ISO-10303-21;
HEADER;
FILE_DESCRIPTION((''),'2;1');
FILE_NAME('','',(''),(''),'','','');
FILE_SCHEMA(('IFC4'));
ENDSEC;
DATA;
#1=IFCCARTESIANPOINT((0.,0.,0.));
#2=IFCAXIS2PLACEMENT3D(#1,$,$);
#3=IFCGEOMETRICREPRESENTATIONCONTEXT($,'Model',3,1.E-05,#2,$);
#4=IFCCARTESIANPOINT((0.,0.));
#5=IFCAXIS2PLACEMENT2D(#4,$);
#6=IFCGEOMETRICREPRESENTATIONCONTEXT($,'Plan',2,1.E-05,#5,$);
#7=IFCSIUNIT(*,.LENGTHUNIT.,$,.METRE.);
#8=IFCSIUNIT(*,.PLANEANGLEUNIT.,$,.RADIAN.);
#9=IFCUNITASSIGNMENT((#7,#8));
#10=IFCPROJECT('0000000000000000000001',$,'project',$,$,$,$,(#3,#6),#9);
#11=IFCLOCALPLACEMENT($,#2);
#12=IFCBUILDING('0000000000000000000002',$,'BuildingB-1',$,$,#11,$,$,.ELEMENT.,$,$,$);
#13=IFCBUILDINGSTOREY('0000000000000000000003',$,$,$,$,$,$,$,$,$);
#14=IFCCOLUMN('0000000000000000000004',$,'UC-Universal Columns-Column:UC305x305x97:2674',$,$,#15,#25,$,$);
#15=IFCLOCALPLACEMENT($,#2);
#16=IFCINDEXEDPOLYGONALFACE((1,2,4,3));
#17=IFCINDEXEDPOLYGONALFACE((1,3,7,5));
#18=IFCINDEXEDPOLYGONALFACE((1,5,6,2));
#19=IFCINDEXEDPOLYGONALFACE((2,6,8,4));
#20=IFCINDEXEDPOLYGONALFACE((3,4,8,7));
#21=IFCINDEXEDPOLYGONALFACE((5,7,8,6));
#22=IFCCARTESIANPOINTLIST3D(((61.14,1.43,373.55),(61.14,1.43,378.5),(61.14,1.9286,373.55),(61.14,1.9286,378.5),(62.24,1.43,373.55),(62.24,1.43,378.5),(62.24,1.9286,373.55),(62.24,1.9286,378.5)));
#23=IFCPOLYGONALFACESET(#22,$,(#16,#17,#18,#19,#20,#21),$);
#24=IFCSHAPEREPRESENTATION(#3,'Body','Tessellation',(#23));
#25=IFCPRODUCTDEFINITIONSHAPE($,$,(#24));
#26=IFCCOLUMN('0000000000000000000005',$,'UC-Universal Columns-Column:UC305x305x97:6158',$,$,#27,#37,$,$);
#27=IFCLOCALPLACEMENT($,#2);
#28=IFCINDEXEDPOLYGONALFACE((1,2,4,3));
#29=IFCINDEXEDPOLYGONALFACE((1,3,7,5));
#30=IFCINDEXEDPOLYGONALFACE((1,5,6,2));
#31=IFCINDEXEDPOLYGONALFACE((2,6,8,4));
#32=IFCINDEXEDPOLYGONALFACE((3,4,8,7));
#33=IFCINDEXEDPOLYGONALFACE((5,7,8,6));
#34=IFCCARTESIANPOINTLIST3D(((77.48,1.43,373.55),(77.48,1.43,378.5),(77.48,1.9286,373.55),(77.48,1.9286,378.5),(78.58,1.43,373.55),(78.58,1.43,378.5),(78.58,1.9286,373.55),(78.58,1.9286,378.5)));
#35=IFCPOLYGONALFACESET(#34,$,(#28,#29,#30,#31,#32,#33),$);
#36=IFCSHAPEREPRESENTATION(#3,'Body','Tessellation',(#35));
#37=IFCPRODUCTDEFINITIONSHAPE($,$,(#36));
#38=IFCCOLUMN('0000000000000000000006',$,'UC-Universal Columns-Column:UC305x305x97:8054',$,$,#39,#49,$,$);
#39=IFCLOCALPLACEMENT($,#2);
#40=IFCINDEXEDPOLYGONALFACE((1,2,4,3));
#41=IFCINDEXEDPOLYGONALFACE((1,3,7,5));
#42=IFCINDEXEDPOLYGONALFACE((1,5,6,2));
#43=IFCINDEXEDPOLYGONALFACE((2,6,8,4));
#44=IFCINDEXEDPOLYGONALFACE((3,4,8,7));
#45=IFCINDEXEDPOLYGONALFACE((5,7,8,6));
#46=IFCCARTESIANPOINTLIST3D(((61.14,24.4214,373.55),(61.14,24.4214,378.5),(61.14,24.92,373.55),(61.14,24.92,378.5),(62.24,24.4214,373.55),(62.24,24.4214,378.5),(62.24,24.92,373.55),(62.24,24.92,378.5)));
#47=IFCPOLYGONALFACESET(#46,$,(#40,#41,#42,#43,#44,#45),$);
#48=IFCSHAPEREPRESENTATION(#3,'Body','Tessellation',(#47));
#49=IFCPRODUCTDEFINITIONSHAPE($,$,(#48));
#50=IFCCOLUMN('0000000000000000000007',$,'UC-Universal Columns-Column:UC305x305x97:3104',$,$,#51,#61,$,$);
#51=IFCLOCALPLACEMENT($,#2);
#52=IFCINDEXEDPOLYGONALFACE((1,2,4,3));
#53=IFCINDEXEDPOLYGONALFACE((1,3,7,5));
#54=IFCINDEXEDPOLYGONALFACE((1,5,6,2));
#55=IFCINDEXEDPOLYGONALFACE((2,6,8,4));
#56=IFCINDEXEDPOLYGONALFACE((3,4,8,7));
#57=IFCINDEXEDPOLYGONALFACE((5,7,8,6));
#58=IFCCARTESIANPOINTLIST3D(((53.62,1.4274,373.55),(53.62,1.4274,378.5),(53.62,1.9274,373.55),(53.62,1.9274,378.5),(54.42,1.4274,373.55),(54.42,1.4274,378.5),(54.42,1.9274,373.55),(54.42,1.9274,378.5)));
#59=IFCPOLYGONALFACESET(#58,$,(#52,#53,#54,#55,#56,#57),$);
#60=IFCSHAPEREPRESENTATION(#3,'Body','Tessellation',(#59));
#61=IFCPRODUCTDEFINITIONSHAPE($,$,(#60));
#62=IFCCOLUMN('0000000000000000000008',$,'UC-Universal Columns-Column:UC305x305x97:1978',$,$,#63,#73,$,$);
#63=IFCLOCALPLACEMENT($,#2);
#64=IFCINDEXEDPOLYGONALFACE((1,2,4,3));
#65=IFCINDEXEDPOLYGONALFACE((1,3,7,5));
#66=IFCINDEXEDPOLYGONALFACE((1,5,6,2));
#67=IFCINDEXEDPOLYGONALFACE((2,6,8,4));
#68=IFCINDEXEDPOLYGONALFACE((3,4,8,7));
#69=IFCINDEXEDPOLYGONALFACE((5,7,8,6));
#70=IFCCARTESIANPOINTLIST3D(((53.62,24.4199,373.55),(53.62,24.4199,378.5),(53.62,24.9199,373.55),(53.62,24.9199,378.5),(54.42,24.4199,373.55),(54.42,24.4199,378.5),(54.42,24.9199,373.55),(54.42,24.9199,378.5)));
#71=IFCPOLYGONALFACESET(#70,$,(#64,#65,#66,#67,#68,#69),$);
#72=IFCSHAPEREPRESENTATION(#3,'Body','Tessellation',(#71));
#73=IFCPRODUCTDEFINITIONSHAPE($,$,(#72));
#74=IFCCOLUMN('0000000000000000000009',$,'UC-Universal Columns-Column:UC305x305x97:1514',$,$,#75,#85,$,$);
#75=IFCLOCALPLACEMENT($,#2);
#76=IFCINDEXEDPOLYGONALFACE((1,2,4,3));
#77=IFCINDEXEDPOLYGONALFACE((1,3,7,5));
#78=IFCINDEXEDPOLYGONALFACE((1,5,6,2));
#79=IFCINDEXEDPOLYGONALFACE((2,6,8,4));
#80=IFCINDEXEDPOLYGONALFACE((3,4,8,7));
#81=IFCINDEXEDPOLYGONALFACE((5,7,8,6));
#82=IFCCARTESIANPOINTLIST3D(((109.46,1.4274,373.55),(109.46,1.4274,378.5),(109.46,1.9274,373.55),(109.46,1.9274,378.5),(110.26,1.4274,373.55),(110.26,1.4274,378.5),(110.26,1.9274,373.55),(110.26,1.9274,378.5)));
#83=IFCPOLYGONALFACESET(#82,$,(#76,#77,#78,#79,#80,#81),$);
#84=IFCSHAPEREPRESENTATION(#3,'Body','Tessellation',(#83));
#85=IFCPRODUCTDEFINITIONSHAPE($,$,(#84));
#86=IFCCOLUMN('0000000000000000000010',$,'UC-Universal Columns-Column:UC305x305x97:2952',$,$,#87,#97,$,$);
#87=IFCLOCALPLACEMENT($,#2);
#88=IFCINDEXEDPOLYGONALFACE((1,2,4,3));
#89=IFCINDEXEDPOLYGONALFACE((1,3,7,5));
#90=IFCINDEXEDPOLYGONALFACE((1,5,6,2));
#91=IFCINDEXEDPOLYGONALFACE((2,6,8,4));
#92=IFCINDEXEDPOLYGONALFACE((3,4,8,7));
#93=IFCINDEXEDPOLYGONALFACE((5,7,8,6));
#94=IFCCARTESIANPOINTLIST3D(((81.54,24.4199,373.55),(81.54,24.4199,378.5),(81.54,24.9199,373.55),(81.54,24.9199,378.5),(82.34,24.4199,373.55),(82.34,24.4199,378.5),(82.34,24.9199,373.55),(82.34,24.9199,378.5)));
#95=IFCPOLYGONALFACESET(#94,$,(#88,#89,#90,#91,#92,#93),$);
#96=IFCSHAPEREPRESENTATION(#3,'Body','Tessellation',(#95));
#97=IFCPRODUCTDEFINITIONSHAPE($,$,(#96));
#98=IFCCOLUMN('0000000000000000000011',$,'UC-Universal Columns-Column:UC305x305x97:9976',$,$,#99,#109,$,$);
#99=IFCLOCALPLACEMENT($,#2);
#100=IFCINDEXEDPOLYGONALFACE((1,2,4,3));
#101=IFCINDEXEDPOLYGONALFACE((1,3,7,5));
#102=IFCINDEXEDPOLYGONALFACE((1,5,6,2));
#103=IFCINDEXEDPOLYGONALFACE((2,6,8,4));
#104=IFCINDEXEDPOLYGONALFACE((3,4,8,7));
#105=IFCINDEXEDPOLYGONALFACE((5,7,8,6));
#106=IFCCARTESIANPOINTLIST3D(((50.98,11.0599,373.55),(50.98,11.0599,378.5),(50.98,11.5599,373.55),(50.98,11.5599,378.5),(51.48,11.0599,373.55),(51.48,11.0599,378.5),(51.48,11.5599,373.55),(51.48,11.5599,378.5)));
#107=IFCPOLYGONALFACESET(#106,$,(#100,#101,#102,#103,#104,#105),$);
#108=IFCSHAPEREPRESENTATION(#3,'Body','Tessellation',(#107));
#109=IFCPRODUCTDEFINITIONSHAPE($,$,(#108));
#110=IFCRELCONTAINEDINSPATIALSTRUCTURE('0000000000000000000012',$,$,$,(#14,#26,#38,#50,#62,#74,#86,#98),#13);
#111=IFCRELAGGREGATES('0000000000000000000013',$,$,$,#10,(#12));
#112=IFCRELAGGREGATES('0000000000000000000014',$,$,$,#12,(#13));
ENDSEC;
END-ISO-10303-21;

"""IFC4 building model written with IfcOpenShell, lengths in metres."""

from ifc_helpers import new_model, si_unit, origin, origin_2d, place, context, project, spatial, polyline, outline, extrude, element, save


model = new_model("IFC4")

# Units and contexts
model_context = context("Model", 3, precision=1e-05, world=origin())
plan_context = context("Plan", 2, precision=1e-05, world=origin_2d())
ifc_project = project(units=[si_unit("LENGTHUNIT", "METRE"), si_unit("PLANEANGLEUNIT", "RADIAN")], contexts=[model_context, plan_context])

# Building, storey
building_placement = place(None, origin())
building = spatial("IfcBuilding", under=ifc_project, at=building_placement, Name="BuildingB-1", CompositionType="ELEMENT")
storey = spatial("IfcBuildingStorey", under=building)

# Columns
element("IfcColumn", 1, inside=storey, Name="UC-Universal Columns-Column:UC305x305x97:2674", context=model_context, shape_type="SweptSolid", body=[
    extrude(outline(polyline([(61.14, 1.43, 378.5), (62.24, 1.43, 378.5), (62.24, 1.9286, 378.5), (61.14, 1.9286, 378.5), (61.14, 1.43, 378.5)])), None, (0.0, 0.0, -1.0), 4.95),
])
element("IfcColumn", 2, inside=storey, Name="UC-Universal Columns-Column:UC305x305x97:6158", context=model_context, shape_type="SweptSolid", body=[
    extrude(outline(polyline([(77.48, 1.43, 378.5), (78.58, 1.43, 378.5), (78.58, 1.9286, 378.5), (77.48, 1.9286, 378.5), (77.48, 1.43, 378.5)])), None, (0.0, 0.0, -1.0), 4.95),
])
element("IfcColumn", 3, inside=storey, Name="UC-Universal Columns-Column:UC305x305x97:8054", context=model_context, shape_type="SweptSolid", body=[
    extrude(outline(polyline([(61.14, 24.4214, 378.5), (62.24, 24.4214, 378.5), (62.24, 24.92, 378.5), (61.14, 24.92, 378.5), (61.14, 24.4214, 378.5)])), None, (0.0, 0.0, -1.0), 4.95),
])
element("IfcColumn", 4, inside=storey, Name="UC-Universal Columns-Column:UC305x305x97:3104", context=model_context, shape_type="SweptSolid", body=[
    extrude(outline(polyline([(54.42, 1.4274, 378.5), (53.62, 1.4274, 378.5), (53.62, 1.9274, 378.5), (54.42, 1.9274, 378.5), (54.42, 1.4274, 378.5)])), None, (0.0, 0.0, -1.0), 4.95),
])
element("IfcColumn", 5, inside=storey, Name="UC-Universal Columns-Column:UC305x305x97:1978", context=model_context, shape_type="SweptSolid", body=[
    extrude(outline(polyline([(54.42, 24.4199, 378.5), (53.62, 24.4199, 378.5), (53.62, 24.9199, 378.5), (54.42, 24.9199, 378.5), (54.42, 24.4199, 378.5)])), None, (0.0, 0.0, -1.0), 4.95),
])
element("IfcColumn", 6, inside=storey, Name="UC-Universal Columns-Column:UC305x305x97:1514", context=model_context, shape_type="SweptSolid", body=[
    extrude(outline(polyline([(110.26, 1.4274, 378.5), (109.46, 1.4274, 378.5), (109.46, 1.9274, 378.5), (110.26, 1.9274, 378.5), (110.26, 1.4274, 378.5)])), None, (0.0, 0.0, -1.0), 4.95),
])
element("IfcColumn", 7, inside=storey, Name="UC-Universal Columns-Column:UC305x305x97:2952", context=model_context, shape_type="SweptSolid", body=[
    extrude(outline(polyline([(81.54, 24.4199, 378.5), (82.34, 24.4199, 378.5), (82.34, 24.9199, 378.5), (81.54, 24.9199, 378.5), (81.54, 24.4199, 378.5)])), None, (0.0, 0.0, -1.0), 4.95),
])
element("IfcColumn", 8, inside=storey, Name="UC-Universal Columns-Column:UC305x305x97:9976", context=model_context, shape_type="SweptSolid", body=[
    extrude(outline(polyline([(50.98, 11.0599, 378.5), (51.48, 11.0599, 378.5), (51.48, 11.5599, 378.5), (50.98, 11.5599, 378.5), (50.98, 11.0599, 378.5)])), None, (0.0, 0.0, -1.0), 4.95),
])

save(model, "model.ifc")
